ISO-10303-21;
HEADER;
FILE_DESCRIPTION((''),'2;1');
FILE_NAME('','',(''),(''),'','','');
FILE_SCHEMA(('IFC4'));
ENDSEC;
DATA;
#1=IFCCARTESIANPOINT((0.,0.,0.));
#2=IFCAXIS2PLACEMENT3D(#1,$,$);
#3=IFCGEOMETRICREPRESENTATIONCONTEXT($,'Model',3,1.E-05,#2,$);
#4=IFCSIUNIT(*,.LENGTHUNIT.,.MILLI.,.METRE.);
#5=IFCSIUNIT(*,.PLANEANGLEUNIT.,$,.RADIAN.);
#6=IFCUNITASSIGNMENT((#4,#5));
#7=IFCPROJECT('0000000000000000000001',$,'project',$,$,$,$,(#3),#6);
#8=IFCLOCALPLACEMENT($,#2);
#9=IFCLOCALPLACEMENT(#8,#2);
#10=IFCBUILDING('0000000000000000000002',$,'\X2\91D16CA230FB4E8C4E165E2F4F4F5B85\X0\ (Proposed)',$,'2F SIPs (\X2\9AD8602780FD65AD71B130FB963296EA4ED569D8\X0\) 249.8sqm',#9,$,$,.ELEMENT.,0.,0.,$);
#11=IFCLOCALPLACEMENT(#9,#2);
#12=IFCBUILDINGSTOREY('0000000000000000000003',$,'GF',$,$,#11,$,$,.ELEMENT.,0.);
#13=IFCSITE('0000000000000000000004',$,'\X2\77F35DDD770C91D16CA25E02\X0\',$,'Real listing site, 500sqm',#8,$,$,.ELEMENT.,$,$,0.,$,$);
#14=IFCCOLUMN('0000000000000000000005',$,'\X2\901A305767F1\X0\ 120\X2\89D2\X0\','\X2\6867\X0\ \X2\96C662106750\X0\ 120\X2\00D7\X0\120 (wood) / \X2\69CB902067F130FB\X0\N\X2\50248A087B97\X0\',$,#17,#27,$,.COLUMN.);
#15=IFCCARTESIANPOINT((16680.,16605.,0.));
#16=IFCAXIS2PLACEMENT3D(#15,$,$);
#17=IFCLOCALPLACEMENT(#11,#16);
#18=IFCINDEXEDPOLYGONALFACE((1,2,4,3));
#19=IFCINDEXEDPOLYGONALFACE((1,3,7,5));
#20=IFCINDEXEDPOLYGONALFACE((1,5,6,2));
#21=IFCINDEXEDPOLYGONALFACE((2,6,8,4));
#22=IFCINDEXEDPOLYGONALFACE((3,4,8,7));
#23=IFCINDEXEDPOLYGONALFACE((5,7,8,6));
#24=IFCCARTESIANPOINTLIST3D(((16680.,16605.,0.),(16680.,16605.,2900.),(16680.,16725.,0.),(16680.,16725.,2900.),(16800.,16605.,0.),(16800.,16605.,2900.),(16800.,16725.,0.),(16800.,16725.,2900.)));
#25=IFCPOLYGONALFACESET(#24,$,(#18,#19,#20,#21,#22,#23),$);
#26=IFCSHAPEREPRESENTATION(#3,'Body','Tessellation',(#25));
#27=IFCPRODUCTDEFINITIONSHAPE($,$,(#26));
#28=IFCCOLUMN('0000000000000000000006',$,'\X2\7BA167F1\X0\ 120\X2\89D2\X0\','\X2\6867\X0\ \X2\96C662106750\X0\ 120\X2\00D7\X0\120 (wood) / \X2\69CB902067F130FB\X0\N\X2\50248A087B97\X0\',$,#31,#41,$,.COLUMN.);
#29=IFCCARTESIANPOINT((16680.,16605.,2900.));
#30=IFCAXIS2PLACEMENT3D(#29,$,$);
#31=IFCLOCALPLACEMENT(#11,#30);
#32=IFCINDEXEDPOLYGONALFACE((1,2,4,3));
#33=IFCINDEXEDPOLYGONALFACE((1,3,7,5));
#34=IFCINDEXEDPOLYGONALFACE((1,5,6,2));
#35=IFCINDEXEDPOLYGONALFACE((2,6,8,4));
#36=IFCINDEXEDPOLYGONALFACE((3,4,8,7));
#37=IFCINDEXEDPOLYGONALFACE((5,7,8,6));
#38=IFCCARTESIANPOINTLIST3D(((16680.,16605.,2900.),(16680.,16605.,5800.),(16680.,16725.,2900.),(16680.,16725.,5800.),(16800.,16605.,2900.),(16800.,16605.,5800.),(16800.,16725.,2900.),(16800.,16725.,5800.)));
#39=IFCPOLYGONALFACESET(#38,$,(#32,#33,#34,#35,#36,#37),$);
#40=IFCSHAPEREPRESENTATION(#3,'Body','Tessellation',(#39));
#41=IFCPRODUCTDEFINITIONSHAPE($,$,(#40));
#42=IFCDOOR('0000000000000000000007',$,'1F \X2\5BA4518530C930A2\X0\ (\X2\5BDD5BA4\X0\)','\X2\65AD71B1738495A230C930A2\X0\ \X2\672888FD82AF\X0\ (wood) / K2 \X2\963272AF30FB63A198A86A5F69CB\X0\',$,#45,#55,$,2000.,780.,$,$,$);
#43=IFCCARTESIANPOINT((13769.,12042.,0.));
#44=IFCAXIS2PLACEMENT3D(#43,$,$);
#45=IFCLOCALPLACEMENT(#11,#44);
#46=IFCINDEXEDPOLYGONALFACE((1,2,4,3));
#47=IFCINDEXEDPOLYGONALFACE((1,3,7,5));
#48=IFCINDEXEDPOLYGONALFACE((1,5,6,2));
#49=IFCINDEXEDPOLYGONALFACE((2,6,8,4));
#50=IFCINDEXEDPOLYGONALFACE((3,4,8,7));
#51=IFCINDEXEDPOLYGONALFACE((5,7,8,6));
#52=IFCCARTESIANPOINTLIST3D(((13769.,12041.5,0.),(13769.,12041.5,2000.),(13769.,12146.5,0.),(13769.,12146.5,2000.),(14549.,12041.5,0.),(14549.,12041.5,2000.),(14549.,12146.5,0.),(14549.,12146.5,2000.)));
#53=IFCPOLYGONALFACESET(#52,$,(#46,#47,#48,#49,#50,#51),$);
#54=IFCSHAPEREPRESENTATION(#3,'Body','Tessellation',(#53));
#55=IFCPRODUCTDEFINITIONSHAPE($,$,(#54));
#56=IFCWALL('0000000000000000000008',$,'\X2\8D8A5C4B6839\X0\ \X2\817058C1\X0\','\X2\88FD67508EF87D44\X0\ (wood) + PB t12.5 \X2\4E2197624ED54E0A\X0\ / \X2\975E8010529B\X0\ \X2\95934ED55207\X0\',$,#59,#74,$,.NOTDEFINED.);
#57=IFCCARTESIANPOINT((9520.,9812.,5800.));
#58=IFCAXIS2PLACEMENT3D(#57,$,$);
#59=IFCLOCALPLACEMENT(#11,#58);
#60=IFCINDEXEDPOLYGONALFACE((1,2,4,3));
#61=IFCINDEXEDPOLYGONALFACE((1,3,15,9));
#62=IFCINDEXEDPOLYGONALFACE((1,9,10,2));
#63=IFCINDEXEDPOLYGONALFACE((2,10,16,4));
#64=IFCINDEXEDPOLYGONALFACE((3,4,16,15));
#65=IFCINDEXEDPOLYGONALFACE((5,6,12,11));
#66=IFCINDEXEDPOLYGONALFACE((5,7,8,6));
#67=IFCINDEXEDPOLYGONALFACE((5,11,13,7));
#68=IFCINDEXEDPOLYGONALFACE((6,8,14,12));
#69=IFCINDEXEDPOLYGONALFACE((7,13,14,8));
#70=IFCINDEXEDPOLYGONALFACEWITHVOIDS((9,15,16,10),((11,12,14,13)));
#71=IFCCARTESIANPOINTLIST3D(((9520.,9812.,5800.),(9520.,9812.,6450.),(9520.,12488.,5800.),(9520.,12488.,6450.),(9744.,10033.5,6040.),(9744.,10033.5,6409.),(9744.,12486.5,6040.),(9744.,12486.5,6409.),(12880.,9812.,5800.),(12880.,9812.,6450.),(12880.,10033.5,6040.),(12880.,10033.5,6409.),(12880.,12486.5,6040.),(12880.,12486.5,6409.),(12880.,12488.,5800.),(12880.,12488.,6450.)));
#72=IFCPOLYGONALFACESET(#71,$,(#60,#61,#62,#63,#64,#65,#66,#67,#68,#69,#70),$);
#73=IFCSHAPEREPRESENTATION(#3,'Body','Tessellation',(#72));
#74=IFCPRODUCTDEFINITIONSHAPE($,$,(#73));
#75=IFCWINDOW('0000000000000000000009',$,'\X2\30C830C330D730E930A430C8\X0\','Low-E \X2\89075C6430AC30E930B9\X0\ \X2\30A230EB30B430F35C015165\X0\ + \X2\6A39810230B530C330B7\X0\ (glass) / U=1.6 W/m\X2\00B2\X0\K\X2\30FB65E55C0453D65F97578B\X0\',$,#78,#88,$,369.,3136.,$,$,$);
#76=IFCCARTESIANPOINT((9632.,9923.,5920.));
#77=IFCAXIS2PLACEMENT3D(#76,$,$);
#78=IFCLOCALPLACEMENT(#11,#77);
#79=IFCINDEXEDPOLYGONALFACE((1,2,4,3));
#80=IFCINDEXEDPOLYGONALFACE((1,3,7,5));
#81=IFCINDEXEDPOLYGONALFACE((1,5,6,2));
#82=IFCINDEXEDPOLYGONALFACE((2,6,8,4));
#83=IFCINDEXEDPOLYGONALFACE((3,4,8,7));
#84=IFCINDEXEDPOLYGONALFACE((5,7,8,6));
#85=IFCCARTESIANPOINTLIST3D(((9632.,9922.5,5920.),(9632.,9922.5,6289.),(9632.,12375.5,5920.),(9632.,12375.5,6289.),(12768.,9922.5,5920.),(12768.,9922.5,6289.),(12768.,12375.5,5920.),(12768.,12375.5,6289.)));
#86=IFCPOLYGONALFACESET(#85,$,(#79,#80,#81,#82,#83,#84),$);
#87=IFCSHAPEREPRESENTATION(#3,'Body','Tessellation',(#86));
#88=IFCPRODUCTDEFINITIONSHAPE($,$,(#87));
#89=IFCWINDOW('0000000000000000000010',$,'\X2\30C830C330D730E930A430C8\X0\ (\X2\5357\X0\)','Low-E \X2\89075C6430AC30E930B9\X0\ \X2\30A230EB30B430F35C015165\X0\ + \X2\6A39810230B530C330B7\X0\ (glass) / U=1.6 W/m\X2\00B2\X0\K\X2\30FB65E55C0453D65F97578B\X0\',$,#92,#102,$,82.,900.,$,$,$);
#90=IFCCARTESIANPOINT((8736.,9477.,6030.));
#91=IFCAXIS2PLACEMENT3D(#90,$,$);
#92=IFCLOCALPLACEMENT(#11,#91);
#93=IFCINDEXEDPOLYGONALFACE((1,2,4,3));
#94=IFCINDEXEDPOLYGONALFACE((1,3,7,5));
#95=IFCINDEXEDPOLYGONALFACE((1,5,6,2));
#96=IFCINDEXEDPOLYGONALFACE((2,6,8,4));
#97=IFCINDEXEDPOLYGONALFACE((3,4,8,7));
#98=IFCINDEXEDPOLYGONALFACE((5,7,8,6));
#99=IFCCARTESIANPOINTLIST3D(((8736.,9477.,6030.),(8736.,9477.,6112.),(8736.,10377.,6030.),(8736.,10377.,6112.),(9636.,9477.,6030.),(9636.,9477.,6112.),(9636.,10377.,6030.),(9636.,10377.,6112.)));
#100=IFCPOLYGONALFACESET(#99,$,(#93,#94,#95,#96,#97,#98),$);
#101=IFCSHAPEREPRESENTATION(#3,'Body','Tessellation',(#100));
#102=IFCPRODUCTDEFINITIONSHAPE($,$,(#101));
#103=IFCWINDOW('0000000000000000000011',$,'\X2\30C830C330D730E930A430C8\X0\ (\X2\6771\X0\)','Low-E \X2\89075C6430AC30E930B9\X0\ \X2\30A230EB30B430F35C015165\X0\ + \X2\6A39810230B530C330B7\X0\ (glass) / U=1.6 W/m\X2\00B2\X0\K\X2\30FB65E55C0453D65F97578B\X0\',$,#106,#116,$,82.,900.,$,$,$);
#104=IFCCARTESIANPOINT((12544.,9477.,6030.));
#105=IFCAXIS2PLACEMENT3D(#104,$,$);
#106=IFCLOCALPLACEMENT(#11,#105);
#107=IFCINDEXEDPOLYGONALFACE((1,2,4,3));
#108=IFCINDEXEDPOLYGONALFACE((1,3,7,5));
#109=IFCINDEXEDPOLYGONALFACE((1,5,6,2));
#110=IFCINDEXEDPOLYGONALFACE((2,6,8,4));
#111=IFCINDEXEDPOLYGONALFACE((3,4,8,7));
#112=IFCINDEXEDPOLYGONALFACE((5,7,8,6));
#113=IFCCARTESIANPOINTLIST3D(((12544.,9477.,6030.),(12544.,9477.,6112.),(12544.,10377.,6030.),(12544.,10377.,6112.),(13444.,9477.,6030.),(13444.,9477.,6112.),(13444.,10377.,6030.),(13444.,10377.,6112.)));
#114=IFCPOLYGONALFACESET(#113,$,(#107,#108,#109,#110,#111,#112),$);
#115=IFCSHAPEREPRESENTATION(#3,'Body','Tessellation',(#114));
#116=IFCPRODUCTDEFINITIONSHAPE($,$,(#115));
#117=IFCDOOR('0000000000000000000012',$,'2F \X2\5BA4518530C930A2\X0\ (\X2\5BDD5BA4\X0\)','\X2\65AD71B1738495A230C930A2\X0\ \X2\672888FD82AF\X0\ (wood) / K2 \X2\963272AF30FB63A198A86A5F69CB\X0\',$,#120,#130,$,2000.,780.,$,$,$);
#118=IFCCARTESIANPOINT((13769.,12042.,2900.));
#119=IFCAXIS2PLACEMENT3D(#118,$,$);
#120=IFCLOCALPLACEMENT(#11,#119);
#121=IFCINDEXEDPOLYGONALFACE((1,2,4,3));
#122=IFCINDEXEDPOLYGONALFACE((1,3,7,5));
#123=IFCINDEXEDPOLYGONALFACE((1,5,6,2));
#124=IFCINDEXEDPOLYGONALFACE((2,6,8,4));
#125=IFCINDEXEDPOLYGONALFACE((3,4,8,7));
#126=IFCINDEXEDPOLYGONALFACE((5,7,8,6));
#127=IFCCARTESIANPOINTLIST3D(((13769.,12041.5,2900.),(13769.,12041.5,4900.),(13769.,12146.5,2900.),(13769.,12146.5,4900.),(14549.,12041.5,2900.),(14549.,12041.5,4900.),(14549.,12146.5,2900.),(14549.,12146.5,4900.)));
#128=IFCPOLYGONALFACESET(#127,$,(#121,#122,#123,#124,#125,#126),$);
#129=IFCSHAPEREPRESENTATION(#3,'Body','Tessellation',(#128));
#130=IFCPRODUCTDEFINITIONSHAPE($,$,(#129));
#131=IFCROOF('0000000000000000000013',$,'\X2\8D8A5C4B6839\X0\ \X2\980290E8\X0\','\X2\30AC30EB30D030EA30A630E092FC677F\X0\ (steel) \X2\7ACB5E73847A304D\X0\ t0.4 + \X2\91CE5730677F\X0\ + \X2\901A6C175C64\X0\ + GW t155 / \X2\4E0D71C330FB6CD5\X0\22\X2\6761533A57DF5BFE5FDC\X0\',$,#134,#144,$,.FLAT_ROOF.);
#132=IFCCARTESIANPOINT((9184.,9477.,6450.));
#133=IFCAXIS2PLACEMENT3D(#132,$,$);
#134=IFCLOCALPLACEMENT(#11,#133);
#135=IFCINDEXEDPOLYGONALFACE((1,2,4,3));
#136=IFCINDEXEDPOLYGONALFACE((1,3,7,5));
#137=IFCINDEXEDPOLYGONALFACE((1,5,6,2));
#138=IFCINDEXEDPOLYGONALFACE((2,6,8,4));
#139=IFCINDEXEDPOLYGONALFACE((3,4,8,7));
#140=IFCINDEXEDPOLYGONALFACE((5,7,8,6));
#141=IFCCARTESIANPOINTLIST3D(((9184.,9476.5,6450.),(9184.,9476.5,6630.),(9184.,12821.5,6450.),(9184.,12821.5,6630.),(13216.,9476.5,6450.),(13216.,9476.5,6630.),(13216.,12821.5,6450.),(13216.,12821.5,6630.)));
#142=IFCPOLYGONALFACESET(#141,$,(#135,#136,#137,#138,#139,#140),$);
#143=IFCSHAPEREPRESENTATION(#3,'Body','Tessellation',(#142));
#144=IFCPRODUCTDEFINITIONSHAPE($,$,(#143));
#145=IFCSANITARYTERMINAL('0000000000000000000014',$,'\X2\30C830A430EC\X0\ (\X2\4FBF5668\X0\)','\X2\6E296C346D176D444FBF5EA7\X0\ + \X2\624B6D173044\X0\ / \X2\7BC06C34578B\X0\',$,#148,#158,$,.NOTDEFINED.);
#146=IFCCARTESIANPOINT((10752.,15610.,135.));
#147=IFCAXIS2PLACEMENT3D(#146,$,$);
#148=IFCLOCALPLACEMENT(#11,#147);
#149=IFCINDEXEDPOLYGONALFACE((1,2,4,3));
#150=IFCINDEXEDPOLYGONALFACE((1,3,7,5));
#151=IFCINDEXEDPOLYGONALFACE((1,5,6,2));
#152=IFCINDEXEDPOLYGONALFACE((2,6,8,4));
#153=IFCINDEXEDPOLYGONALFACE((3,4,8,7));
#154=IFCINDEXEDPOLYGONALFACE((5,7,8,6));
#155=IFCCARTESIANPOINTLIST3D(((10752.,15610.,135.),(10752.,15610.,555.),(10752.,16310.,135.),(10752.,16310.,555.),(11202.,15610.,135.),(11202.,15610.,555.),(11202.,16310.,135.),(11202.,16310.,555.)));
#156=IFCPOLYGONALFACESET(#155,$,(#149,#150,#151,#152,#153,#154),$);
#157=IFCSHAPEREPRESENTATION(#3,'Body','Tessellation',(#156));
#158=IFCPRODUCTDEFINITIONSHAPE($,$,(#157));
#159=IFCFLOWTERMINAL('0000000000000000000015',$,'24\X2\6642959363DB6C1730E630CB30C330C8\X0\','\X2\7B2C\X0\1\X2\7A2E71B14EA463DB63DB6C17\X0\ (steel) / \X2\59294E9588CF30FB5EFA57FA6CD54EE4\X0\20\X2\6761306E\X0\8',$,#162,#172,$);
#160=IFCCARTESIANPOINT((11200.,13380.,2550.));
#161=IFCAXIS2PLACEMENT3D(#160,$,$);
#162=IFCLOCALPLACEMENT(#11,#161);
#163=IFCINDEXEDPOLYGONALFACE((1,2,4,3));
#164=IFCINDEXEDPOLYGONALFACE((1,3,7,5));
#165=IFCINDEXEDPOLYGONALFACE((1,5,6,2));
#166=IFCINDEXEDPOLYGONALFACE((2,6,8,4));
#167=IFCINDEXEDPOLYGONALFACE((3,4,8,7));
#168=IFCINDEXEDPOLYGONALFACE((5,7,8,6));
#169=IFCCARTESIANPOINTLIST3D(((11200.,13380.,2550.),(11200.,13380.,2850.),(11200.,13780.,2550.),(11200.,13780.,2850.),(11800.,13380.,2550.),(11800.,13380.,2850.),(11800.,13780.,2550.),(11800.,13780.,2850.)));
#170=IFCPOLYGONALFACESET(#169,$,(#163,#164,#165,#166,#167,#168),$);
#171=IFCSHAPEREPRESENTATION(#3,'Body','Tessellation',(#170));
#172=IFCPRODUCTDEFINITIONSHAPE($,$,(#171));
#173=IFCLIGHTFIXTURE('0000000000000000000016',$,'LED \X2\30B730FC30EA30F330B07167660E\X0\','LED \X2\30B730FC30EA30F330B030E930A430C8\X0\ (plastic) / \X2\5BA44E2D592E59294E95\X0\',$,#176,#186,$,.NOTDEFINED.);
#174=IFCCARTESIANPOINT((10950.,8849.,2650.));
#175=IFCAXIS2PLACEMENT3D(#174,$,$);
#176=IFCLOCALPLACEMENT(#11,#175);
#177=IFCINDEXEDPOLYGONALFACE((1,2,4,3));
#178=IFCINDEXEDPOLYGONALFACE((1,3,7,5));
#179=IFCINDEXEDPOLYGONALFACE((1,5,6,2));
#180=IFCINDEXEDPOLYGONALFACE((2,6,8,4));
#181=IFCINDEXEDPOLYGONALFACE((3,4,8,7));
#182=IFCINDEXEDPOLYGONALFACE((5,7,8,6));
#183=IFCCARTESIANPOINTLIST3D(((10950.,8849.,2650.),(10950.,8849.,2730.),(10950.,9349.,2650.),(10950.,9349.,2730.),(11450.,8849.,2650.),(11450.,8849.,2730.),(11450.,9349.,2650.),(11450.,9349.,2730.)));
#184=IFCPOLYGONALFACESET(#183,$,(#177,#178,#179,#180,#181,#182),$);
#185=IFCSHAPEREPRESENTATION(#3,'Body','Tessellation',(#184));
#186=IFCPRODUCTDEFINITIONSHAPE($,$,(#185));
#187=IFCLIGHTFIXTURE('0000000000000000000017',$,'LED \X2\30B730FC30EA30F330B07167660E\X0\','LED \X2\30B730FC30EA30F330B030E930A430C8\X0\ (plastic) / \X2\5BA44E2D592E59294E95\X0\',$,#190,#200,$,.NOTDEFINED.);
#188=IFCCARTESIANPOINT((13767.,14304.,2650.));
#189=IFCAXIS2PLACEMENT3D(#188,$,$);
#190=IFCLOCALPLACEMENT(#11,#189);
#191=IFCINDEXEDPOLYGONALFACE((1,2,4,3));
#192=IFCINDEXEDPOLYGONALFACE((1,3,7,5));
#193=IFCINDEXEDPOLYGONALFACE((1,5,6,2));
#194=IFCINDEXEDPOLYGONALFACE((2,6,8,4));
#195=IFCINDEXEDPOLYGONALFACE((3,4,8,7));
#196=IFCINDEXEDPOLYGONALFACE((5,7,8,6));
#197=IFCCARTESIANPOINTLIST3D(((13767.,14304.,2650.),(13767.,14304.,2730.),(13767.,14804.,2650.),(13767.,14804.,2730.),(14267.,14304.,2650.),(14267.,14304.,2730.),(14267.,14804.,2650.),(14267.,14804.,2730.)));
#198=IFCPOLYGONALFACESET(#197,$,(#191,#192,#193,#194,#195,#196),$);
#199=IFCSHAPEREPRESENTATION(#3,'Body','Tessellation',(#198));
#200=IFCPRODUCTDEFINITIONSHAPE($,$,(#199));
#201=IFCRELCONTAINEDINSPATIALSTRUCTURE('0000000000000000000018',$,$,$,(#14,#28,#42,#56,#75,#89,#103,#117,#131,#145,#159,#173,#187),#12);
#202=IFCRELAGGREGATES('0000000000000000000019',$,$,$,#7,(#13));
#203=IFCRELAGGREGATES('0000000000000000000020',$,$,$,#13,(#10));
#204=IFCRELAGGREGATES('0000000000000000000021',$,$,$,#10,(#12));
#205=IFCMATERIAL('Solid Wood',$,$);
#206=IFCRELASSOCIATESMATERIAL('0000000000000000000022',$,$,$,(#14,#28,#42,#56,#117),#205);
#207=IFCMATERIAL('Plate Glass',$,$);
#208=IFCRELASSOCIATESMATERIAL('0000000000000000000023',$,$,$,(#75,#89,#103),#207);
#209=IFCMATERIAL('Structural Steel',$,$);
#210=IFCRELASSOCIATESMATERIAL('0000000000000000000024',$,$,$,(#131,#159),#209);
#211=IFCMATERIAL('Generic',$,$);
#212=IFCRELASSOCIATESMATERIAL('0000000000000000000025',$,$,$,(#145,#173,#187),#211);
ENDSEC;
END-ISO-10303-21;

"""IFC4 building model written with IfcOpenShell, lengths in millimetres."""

from ifc_helpers import new_model, si_unit, frame, frame_2d, origin, place, context, project, spatial, rectangle, extrude, material, element, fill, save


model = new_model("IFC4")

# Units and contexts
model_context = context("Model", 3, precision=1e-05, world=origin())
ifc_project = project(units=[si_unit("LENGTHUNIT", "METRE", prefix="MILLI"), si_unit("PLANEANGLEUNIT", "RADIAN")], contexts=[model_context])

# Site, building, storey
site_placement = place(None, origin())
site = spatial("IfcSite", under=ifc_project, at=site_placement, Name="石川県金沢市", ObjectType="Real listing site, 500sqm", CompositionType="ELEMENT", RefElevation=0.0)
building_placement = place(site_placement, origin())
building = spatial("IfcBuilding", under=site, at=building_placement, Name="金沢・二世帯住宅 (Proposed)", ObjectType="2F SIPs (高性能断熱・防雪仕様) 249.8sqm", CompositionType="ELEMENT", ElevationOfRefHeight=0.0, ElevationOfTerrain=0.0)
storey_placement = place(building_placement, origin())
storey = spatial("IfcBuildingStorey", under=building, at=storey_placement, Name="GF", CompositionType="ELEMENT", Elevation=0.0)

# Columns
ifc_material_1 = material(Name="Solid Wood")
column_1_placement = place(storey_placement, frame((16680.0, 16605.0, 0.0)))
element("IfcColumn", 1, at=column_1_placement, inside=storey, material=ifc_material_1, Name="通し柱 120角", Description="桧 集成材 120×120 (wood) / 構造柱・N値計算", PredefinedType="COLUMN", context=model_context, shape_type="SweptSolid", body=[
    extrude(rectangle(XDim=120.0, YDim=120.0, at=frame_2d((60.0, 60.0))), frame((16680.0, 16605.0, 0.0)), (0.0, 0.0, 1.0), 2900.0),
])
column_2_placement = place(storey_placement, frame((16680.0, 16605.0, 2900.0)))
element("IfcColumn", 2, at=column_2_placement, inside=storey, material=ifc_material_1, Name="管柱 120角", Description="桧 集成材 120×120 (wood) / 構造柱・N値計算", PredefinedType="COLUMN", context=model_context, shape_type="SweptSolid", body=[
    extrude(rectangle(XDim=120.0, YDim=120.0, at=frame_2d((60.0, 60.0))), frame((16680.0, 16605.0, 2900.0)), (0.0, 0.0, 1.0), 2900.0),
])

# Door
door_1_placement = place(storey_placement, frame((13769.0, 12042.0, 0.0)))
element("IfcDoor", 3, at=door_1_placement, inside=storey, material=ifc_material_1, Name="1F 室内ドア (寝室)", Description="断熱玄関ドア 木製芯 (wood) / K2 防犯・採風機構", OverallHeight=2000.0, OverallWidth=780.0, context=model_context, shape_type="SweptSolid", body=[
    extrude(rectangle(XDim=780.0, YDim=105.0, at=frame_2d((390.0, 52.0))), frame((13769.0, 12042.0, 0.0)), (0.0, 0.0, 1.0), 2000.0),
])

# Wall, openings, windows
wall_1_placement = place(storey_placement, frame((9520.0, 9812.0, 5800.0)))
wall_1 = element("IfcWall", 4, at=wall_1_placement, inside=storey, material=ifc_material_1, Name="越屋根 腰壁", Description="製材軸組 (wood) + PB t12.5 両面仕上 / 非耐力 間仕切", PredefinedType="NOTDEFINED", context=model_context, shape_type="SweptSolid", body=[
    extrude(rectangle(XDim=3360.0, YDim=2676.0, at=frame_2d((1680.0, 1338.0))), frame((9520.0, 9812.0, 5800.0)), (0.0, 0.0, 1.0), 650.0),
])
opening_1_placement = place(storey_placement, frame((9632.0, 9923.0, 5920.0)))
opening_1 = element("IfcOpeningElement", 5, at=opening_1_placement, cuts=wall_1, PredefinedType="NOTDEFINED", context=model_context, shape_type="SweptSolid", body=[
    extrude(rectangle(XDim=3136.0, YDim=2453.0, at=frame_2d((1568.0, 1226.0))), frame((9632.0, 9923.0, 5920.0)), (0.0, 0.0, 1.0), 369.0),
])
opening_2_placement = place(storey_placement, frame((8736.0, 9477.0, 6030.0)))
opening_2 = element("IfcOpeningElement", 6, at=opening_2_placement, cuts=wall_1, PredefinedType="NOTDEFINED", context=model_context, shape_type="SweptSolid", body=[
    extrude(rectangle(XDim=900.0, YDim=900.0, at=frame_2d((450.0, 450.0))), frame((8736.0, 9477.0, 6030.0)), (0.0, 0.0, 1.0), 82.0),
])
opening_3_placement = place(storey_placement, frame((12544.0, 9477.0, 6030.0)))
opening_3 = element("IfcOpeningElement", 7, at=opening_3_placement, cuts=wall_1, PredefinedType="NOTDEFINED", context=model_context, shape_type="SweptSolid", body=[
    extrude(rectangle(XDim=900.0, YDim=900.0, at=frame_2d((450.0, 450.0))), frame((12544.0, 9477.0, 6030.0)), (0.0, 0.0, 1.0), 82.0),
])
ifc_material_2 = material(Name="Plate Glass")
window_1_placement = place(storey_placement, frame((9632.0, 9923.0, 5920.0)))
window_1 = element("IfcWindow", 8, at=window_1_placement, inside=storey, material=ifc_material_2, Name="トップライト", Description="Low-E 複層ガラス アルゴン封入 + 樹脂サッシ (glass) / U=1.6 W/m²K・日射取得型", OverallHeight=369.0, OverallWidth=3136.0, context=model_context, shape_type="SweptSolid", body=[
    extrude(rectangle(XDim=3136.0, YDim=2453.0, at=frame_2d((1568.0, 1226.0))), frame((9632.0, 9923.0, 5920.0)), (0.0, 0.0, 1.0), 369.0),
])
fill(opening_1, window_1)
window_2_placement = place(storey_placement, frame((8736.0, 9477.0, 6030.0)))
window_2 = element("IfcWindow", 9, at=window_2_placement, inside=storey, material=ifc_material_2, Name="トップライト (南)", Description="Low-E 複層ガラス アルゴン封入 + 樹脂サッシ (glass) / U=1.6 W/m²K・日射取得型", OverallHeight=82.0, OverallWidth=900.0, context=model_context, shape_type="SweptSolid", body=[
    extrude(rectangle(XDim=900.0, YDim=900.0, at=frame_2d((450.0, 450.0))), frame((8736.0, 9477.0, 6030.0)), (0.0, 0.0, 1.0), 82.0),
])
fill(opening_2, window_2)
window_3_placement = place(storey_placement, frame((12544.0, 9477.0, 6030.0)))
window_3 = element("IfcWindow", 10, at=window_3_placement, inside=storey, material=ifc_material_2, Name="トップライト (東)", Description="Low-E 複層ガラス アルゴン封入 + 樹脂サッシ (glass) / U=1.6 W/m²K・日射取得型", OverallHeight=82.0, OverallWidth=900.0, context=model_context, shape_type="SweptSolid", body=[
    extrude(rectangle(XDim=900.0, YDim=900.0, at=frame_2d((450.0, 450.0))), frame((12544.0, 9477.0, 6030.0)), (0.0, 0.0, 1.0), 82.0),
])
fill(opening_3, window_3)

# Door
door_2_placement = place(storey_placement, frame((13769.0, 12042.0, 2900.0)))
element("IfcDoor", 11, at=door_2_placement, inside=storey, material=ifc_material_1, Name="2F 室内ドア (寝室)", Description="断熱玄関ドア 木製芯 (wood) / K2 防犯・採風機構", OverallHeight=2000.0, OverallWidth=780.0, context=model_context, shape_type="SweptSolid", body=[
    extrude(rectangle(XDim=780.0, YDim=105.0, at=frame_2d((390.0, 52.0))), frame((13769.0, 12042.0, 2900.0)), (0.0, 0.0, 1.0), 2000.0),
])

# Roof
ifc_material_3 = material(Name="Structural Steel")
roof_placement = place(storey_placement, frame((9184.0, 9477.0, 6450.0)))
element("IfcRoof", 12, at=roof_placement, inside=storey, material=ifc_material_3, Name="越屋根 頂部", Description="ガルバリウム鋼板 (steel) 立平葺き t0.4 + 野地板 + 通気層 + GW t155 / 不燃・法22条区域対応", PredefinedType="FLAT_ROOF", context=model_context, shape_type="SweptSolid", body=[
    extrude(rectangle(XDim=4032.0, YDim=3345.0, at=frame_2d((2016.0, 1672.0))), frame((9184.0, 9477.0, 6450.0)), (0.0, 0.0, 1.0), 180.0),
])

# Sanitary terminal
ifc_material_4 = material(Name="Generic")
sanitary_terminal_placement = place(storey_placement, frame((10752.0, 15610.0, 135.0)))
element("IfcSanitaryTerminal", 13, at=sanitary_terminal_placement, inside=storey, material=ifc_material_4, Name="トイレ (便器)", Description="温水洗浄便座 + 手洗い / 節水型", PredefinedType="NOTDEFINED", context=model_context, shape_type="SweptSolid", body=[
    extrude(rectangle(XDim=450.0, YDim=700.0, at=frame_2d((225.0, 350.0))), frame((10752.0, 15610.0, 135.0)), (0.0, 0.0, 1.0), 420.0),
])

# Flow terminal
flow_terminal_placement = place(storey_placement, frame((11200.0, 13380.0, 2550.0)))
element("IfcFlowTerminal", 14, at=flow_terminal_placement, inside=storey, material=ifc_material_3, Name="24時間換気ユニット", Description="第1種熱交換換気 (steel) / 天井裏・建基法令20条の8", context=model_context, shape_type="SweptSolid", body=[
    extrude(rectangle(XDim=600.0, YDim=400.0, at=frame_2d((300.0, 200.0))), frame((11200.0, 13380.0, 2550.0)), (0.0, 0.0, 1.0), 300.0),
])

# Light fixtures
light_fixture_1_placement = place(storey_placement, frame((10950.0, 8849.0, 2650.0)))
element("IfcLightFixture", 15, at=light_fixture_1_placement, inside=storey, material=ifc_material_4, Name="LED シーリング照明", Description="LED シーリングライト (plastic) / 室中央天井", PredefinedType="NOTDEFINED", context=model_context, shape_type="SweptSolid", body=[
    extrude(rectangle(XDim=500.0, YDim=500.0, at=frame_2d((250.0, 250.0))), frame((10950.0, 8849.0, 2650.0)), (0.0, 0.0, 1.0), 80.0),
])
light_fixture_2_placement = place(storey_placement, frame((13767.0, 14304.0, 2650.0)))
element("IfcLightFixture", 16, at=light_fixture_2_placement, inside=storey, material=ifc_material_4, Name="LED シーリング照明", Description="LED シーリングライト (plastic) / 室中央天井", PredefinedType="NOTDEFINED", context=model_context, shape_type="SweptSolid", body=[
    extrude(rectangle(XDim=500.0, YDim=500.0, at=frame_2d((250.0, 250.0))), frame((13767.0, 14304.0, 2650.0)), (0.0, 0.0, 1.0), 80.0),
])

save(model, "model.ifc")
